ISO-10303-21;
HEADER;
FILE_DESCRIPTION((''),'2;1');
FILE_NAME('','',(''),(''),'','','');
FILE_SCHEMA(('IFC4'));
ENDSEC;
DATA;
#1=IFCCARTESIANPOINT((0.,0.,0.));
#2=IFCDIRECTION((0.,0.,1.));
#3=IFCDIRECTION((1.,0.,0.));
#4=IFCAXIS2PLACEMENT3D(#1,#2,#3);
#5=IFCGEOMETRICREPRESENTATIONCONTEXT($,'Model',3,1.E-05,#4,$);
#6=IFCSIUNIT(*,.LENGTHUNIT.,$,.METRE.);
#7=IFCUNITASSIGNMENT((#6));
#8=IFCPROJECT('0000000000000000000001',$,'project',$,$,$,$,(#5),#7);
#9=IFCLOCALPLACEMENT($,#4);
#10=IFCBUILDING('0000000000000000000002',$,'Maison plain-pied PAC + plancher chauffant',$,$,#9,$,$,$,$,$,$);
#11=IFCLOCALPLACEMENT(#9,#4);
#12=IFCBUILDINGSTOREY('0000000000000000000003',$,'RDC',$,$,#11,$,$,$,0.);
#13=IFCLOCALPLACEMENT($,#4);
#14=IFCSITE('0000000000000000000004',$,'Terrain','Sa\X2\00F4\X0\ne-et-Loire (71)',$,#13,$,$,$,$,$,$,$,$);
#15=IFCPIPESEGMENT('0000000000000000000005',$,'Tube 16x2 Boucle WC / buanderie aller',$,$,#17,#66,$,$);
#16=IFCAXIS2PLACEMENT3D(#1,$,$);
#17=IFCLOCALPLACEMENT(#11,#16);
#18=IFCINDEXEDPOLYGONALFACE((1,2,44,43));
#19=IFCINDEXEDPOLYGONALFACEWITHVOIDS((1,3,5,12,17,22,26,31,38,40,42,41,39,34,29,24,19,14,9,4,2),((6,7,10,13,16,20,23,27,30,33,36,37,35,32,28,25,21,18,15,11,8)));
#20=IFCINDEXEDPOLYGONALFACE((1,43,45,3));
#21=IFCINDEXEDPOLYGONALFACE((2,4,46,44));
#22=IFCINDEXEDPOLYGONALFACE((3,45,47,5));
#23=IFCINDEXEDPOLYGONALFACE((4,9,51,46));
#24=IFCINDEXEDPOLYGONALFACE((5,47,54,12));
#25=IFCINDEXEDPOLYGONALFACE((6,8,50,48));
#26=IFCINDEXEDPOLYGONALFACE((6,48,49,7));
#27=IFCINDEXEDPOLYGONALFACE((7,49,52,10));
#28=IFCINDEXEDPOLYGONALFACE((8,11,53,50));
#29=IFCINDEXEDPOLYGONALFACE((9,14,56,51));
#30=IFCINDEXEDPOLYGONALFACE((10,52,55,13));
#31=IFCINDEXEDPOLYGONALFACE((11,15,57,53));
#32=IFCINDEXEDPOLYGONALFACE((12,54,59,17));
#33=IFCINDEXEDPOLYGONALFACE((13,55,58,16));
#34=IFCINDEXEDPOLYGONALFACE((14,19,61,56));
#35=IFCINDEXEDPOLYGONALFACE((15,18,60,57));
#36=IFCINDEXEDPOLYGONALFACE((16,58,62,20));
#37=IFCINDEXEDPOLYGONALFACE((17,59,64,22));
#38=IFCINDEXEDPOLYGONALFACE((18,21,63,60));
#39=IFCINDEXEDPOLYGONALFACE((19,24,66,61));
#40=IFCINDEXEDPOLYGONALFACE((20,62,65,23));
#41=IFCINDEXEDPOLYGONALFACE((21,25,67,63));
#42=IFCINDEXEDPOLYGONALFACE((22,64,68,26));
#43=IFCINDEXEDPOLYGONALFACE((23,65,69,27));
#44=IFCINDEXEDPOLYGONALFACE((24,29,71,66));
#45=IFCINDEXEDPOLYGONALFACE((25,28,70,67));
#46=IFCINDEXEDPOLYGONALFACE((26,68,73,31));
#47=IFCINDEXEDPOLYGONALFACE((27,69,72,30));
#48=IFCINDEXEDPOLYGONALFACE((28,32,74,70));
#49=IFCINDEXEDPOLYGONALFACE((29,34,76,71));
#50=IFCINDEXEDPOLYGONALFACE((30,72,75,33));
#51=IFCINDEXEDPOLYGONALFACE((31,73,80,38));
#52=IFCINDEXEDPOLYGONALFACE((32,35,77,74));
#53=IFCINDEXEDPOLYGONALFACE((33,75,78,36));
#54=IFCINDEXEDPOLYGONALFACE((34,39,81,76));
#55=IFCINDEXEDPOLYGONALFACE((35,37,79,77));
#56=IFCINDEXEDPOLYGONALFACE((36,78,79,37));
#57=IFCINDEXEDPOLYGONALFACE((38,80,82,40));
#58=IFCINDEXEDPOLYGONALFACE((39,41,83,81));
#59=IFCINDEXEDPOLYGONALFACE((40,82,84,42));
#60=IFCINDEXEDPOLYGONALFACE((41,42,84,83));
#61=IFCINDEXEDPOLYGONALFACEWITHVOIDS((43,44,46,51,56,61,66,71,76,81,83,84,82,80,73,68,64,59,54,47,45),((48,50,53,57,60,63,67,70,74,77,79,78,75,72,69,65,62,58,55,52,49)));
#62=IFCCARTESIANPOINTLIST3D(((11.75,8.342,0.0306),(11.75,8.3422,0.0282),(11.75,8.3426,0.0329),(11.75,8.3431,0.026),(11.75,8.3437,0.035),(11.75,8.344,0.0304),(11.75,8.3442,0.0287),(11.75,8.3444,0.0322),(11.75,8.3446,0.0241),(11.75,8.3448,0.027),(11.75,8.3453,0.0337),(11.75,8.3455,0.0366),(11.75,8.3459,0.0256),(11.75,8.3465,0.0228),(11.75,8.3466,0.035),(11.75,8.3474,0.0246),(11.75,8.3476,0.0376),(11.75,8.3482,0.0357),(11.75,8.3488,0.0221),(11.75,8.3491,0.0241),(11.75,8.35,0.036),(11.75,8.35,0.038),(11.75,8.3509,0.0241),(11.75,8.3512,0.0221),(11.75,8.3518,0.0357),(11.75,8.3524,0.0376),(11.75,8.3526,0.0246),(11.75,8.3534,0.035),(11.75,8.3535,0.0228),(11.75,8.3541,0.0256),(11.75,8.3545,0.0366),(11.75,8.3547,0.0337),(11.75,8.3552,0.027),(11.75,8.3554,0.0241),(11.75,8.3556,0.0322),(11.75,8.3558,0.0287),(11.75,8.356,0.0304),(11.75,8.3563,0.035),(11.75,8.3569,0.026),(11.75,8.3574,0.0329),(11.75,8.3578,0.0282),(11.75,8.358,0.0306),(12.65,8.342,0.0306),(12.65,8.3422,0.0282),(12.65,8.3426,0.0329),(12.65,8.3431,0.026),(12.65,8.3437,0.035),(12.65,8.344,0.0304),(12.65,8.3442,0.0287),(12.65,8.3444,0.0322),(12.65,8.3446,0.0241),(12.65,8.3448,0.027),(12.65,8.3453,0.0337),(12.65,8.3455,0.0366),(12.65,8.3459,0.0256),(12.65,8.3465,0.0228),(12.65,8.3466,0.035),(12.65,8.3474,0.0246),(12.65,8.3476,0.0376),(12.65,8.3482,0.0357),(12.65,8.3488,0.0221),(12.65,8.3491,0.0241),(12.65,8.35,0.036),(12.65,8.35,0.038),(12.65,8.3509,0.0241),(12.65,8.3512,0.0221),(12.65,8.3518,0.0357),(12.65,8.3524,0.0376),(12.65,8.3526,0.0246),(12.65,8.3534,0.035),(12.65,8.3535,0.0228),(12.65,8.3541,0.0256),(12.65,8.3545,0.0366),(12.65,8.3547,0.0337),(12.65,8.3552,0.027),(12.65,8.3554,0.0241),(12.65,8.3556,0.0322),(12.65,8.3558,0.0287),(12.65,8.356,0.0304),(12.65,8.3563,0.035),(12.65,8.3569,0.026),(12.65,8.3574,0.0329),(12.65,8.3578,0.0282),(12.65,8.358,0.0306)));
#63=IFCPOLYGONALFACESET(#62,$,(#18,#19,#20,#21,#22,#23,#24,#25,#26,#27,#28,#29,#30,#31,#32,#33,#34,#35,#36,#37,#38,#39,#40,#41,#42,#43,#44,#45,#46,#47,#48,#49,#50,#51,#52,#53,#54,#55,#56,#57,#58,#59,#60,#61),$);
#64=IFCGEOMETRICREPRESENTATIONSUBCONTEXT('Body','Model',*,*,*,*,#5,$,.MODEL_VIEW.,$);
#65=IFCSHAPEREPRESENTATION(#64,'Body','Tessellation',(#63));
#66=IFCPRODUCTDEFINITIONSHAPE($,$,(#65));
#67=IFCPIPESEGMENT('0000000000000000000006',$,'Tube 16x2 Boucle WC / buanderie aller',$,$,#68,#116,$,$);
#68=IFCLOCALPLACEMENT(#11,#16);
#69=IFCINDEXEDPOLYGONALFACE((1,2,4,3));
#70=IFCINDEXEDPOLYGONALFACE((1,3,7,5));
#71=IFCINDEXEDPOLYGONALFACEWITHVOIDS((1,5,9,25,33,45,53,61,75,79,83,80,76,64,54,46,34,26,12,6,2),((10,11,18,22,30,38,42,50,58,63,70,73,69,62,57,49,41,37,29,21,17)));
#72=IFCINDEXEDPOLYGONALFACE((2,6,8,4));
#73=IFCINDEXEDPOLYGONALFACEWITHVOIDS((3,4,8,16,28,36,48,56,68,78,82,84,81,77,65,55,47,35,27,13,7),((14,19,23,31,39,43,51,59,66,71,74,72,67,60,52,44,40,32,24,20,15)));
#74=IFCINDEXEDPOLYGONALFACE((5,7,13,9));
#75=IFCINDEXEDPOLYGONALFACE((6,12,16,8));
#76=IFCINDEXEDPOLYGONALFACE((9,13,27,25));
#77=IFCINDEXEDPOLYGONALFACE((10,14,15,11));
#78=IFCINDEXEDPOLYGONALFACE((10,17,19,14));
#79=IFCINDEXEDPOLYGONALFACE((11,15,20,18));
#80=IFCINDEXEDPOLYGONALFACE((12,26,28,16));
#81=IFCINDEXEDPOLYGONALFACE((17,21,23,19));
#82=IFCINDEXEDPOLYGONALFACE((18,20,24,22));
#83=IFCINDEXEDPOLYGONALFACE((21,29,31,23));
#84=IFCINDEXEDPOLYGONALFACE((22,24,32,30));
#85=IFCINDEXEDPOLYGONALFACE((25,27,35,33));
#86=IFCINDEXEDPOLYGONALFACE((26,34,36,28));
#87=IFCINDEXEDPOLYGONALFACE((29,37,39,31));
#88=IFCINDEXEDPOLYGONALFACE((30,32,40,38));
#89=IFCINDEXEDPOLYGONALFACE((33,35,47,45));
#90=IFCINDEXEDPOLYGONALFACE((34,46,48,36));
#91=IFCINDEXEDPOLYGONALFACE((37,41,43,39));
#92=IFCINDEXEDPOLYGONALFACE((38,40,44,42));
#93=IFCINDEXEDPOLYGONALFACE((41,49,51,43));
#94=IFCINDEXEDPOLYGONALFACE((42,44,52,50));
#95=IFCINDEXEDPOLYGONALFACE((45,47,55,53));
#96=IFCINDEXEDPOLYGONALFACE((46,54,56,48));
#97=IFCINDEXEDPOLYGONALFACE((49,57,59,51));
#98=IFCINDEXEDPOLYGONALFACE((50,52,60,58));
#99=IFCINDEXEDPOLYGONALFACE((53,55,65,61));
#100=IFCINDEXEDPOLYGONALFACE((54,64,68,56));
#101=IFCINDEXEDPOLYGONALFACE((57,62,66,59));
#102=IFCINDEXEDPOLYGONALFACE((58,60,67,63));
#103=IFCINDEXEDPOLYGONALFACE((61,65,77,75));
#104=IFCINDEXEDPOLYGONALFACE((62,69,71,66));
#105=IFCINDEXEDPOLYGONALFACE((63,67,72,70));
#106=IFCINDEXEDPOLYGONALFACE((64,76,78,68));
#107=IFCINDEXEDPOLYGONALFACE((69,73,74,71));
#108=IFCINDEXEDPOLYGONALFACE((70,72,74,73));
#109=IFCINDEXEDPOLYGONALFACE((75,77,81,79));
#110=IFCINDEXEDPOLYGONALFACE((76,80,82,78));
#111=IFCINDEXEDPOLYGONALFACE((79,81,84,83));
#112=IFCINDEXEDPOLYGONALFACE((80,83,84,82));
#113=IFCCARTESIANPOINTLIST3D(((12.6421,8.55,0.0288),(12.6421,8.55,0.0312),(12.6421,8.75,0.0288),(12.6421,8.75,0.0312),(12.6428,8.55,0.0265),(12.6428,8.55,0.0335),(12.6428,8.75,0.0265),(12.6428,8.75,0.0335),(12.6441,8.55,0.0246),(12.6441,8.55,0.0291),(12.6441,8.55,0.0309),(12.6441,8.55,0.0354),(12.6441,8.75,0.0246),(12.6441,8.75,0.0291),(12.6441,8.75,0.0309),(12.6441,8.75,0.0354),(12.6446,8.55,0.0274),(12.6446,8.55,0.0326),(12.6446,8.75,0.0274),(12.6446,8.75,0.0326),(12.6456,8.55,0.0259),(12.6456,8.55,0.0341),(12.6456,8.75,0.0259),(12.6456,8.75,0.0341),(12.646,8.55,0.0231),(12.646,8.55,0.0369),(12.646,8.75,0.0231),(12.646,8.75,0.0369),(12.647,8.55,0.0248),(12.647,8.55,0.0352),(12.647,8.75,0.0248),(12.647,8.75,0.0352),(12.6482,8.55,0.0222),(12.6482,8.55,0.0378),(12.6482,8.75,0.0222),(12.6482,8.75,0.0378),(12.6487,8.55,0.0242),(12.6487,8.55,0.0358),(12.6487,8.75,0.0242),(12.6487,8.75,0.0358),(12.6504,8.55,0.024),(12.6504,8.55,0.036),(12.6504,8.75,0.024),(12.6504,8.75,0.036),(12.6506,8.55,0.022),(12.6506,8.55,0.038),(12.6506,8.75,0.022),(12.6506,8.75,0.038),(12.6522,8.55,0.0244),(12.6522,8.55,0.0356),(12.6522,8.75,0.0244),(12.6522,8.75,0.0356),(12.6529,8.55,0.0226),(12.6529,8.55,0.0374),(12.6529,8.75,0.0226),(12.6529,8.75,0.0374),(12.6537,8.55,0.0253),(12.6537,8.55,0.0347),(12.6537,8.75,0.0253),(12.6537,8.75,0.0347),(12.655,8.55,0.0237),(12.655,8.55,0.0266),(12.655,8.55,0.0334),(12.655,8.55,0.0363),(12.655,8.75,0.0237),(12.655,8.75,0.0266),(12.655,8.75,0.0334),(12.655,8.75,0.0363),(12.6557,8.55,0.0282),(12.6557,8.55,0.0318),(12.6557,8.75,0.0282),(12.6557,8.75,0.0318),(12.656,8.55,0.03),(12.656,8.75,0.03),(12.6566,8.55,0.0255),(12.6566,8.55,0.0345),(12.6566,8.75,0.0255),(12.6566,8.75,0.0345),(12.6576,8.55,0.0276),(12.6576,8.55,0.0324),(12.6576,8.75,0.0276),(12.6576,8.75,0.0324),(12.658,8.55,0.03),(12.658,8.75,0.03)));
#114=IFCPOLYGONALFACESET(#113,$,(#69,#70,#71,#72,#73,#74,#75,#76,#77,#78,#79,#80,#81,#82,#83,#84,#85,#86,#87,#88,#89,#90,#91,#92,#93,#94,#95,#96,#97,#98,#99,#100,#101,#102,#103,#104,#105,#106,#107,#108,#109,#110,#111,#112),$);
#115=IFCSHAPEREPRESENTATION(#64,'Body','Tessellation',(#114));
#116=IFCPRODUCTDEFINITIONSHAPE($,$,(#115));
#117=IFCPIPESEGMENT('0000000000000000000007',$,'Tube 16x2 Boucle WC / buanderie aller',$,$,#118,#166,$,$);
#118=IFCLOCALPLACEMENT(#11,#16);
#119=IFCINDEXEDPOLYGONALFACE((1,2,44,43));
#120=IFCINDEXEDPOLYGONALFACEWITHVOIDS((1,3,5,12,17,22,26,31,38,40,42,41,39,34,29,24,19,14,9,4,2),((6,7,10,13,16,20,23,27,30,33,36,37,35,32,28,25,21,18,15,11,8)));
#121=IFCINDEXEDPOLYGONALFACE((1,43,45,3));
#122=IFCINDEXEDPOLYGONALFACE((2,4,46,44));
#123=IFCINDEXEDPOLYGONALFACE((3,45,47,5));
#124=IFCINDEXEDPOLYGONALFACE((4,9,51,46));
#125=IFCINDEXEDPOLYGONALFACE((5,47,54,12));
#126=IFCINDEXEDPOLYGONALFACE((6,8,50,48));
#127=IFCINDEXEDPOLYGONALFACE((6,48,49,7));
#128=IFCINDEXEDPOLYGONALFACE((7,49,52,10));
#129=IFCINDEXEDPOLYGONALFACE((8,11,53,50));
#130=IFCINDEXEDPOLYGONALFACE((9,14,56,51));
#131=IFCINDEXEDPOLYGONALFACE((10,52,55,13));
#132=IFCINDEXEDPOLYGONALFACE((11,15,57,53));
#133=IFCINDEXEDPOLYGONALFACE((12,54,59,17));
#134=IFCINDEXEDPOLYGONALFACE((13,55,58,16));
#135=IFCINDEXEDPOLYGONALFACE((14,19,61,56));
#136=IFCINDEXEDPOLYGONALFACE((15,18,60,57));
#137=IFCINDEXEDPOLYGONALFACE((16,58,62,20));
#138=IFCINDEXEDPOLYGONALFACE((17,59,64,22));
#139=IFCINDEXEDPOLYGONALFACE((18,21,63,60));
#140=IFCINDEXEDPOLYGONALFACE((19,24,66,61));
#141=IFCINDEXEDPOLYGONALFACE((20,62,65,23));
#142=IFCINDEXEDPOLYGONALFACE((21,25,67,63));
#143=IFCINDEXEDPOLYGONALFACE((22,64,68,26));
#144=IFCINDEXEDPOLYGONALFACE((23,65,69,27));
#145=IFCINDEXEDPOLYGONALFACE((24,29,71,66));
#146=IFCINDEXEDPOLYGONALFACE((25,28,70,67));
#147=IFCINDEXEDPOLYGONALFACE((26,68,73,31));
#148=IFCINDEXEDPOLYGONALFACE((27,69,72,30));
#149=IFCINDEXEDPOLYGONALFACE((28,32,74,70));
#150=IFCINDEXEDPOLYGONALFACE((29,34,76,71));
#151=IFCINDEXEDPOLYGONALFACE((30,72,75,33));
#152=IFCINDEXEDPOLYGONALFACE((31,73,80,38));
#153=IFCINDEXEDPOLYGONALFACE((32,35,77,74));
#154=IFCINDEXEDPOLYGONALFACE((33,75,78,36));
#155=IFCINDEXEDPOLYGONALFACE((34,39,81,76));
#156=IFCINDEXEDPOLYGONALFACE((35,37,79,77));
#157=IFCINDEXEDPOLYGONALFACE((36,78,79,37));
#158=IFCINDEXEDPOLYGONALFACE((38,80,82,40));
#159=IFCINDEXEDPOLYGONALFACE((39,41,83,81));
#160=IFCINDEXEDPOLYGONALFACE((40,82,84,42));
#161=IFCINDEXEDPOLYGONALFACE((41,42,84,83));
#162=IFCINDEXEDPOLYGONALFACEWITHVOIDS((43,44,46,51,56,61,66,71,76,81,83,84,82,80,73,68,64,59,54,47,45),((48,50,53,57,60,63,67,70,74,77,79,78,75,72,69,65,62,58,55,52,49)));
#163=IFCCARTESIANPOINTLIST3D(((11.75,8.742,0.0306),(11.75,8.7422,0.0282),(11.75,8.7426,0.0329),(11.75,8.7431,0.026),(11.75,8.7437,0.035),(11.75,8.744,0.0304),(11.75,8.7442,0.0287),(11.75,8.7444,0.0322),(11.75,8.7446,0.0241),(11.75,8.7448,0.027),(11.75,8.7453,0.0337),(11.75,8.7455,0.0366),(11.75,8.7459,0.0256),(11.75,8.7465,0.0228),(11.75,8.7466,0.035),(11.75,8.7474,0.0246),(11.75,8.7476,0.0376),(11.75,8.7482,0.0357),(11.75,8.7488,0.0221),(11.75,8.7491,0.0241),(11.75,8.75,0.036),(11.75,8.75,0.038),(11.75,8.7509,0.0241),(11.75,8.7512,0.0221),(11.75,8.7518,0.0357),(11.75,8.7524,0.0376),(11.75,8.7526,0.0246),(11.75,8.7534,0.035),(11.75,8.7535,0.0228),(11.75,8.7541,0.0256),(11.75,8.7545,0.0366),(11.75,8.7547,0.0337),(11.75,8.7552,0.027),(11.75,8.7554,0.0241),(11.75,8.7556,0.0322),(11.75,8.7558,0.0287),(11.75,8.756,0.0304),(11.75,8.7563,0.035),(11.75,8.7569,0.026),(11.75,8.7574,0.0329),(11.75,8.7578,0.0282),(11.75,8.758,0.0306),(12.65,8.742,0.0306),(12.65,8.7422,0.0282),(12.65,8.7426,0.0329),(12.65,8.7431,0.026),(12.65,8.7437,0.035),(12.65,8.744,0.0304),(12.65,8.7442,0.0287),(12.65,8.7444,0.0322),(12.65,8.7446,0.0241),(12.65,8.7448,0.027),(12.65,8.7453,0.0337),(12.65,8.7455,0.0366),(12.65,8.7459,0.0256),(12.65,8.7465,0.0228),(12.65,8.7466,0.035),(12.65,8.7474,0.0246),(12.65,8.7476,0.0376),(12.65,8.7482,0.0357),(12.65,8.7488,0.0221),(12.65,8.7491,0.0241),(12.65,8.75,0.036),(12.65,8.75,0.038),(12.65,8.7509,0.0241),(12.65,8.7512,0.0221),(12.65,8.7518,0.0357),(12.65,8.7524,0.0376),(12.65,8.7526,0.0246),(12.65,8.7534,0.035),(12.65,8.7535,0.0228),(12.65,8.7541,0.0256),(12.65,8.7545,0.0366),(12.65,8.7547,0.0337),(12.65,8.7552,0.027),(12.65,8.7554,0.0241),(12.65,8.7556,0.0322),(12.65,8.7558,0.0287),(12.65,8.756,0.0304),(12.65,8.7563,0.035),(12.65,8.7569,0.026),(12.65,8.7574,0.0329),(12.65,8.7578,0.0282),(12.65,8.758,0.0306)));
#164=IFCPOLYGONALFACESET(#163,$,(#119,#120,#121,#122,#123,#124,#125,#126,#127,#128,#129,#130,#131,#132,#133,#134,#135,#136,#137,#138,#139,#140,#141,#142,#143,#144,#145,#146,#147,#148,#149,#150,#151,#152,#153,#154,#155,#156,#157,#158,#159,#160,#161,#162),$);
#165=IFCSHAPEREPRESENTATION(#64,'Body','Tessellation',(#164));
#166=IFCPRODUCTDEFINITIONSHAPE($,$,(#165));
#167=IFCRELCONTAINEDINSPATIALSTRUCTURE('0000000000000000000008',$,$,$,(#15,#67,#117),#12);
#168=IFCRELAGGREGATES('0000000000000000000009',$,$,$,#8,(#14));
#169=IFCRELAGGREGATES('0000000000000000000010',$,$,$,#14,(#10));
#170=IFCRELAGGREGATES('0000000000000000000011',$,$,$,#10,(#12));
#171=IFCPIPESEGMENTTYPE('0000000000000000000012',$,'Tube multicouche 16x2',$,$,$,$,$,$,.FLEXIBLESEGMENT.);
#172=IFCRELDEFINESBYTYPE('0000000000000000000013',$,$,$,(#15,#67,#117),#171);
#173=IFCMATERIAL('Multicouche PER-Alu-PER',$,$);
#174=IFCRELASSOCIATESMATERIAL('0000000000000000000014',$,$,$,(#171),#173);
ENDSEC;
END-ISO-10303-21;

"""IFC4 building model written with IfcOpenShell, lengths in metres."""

from ifc_helpers import new_model, si_unit, frame, origin_with_axes, place, context, subcontext, project, spatial, hollow_circle, extrude, material, type_object, element, save


model = new_model("IFC4")

# Units and contexts
model_context = context("Model", 3, precision=1e-05, world=origin_with_axes())
body_context = subcontext(model_context, "Body", "Model", "MODEL_VIEW")
ifc_project = project(units=[si_unit("LENGTHUNIT", "METRE")], contexts=[model_context])

# Site, building, storey
site_placement = place(None, origin_with_axes())
site = spatial("IfcSite", under=ifc_project, at=site_placement, Name="Terrain", Description="Saône-et-Loire (71)")
building_placement = place(None, origin_with_axes())
building = spatial("IfcBuilding", under=site, at=building_placement, Name="Maison plain-pied PAC + plancher chauffant")
storey_placement = place(building_placement, origin_with_axes())
storey = spatial("IfcBuildingStorey", under=building, at=storey_placement, Name="RDC", Elevation=0.0)

# Pipe segments
ifc_material_1 = material(Name="Multicouche PER-Alu-PER")
pipe_segment_type_1 = type_object("IfcPipeSegmentType", Name="Tube multicouche 16x2", PredefinedType="FLEXIBLESEGMENT", material=ifc_material_1)
pipe_segment_1_placement = place(storey_placement, frame((12.65, 8.35, 0.03), z_axis=(-1.0, 0.0, 0.0), x_axis=(0.0, 0.0, 1.0)))
element("IfcPipeSegment", 1, at=pipe_segment_1_placement, inside=storey, type_object=pipe_segment_type_1, Name="Tube 16x2 Boucle WC / buanderie aller", context=body_context, shape_type="SweptSolid", body=[
    extrude(hollow_circle(Radius=0.008, WallThickness=0.002), origin_with_axes(), (0.0, 0.0, 1.0), 0.9),
])
pipe_segment_2_placement = place(storey_placement, frame((12.65, 8.55, 0.03), z_axis=(0.0, 1.0, 0.0), x_axis=(1.0, 0.0, 0.0)))
element("IfcPipeSegment", 2, at=pipe_segment_2_placement, inside=storey, type_object=pipe_segment_type_1, Name="Tube 16x2 Boucle WC / buanderie aller", context=body_context, shape_type="SweptSolid", body=[
    extrude(hollow_circle(Radius=0.008, WallThickness=0.002), origin_with_axes(), (0.0, 0.0, 1.0), 0.2),
])
for number, where, z_axis, x_axis, name in (
    (3, (12.65, 8.75, 0.03), (-1.0, 0.0, 0.0), (0.0, 0.0, 1.0), "Tube 16x2 Boucle WC / buanderie aller"),
):
    element("IfcPipeSegment", number, at=place(storey_placement, frame(where, z_axis=z_axis, x_axis=x_axis)), inside=storey, type_object=pipe_segment_type_1, Name=name, context=body_context, shape_type="SweptSolid", body=[
        extrude(hollow_circle(Radius=0.008, WallThickness=0.002), origin_with_axes(), (0.0, 0.0, 1.0), 0.9),
    ])

save(model, "model.ifc")
